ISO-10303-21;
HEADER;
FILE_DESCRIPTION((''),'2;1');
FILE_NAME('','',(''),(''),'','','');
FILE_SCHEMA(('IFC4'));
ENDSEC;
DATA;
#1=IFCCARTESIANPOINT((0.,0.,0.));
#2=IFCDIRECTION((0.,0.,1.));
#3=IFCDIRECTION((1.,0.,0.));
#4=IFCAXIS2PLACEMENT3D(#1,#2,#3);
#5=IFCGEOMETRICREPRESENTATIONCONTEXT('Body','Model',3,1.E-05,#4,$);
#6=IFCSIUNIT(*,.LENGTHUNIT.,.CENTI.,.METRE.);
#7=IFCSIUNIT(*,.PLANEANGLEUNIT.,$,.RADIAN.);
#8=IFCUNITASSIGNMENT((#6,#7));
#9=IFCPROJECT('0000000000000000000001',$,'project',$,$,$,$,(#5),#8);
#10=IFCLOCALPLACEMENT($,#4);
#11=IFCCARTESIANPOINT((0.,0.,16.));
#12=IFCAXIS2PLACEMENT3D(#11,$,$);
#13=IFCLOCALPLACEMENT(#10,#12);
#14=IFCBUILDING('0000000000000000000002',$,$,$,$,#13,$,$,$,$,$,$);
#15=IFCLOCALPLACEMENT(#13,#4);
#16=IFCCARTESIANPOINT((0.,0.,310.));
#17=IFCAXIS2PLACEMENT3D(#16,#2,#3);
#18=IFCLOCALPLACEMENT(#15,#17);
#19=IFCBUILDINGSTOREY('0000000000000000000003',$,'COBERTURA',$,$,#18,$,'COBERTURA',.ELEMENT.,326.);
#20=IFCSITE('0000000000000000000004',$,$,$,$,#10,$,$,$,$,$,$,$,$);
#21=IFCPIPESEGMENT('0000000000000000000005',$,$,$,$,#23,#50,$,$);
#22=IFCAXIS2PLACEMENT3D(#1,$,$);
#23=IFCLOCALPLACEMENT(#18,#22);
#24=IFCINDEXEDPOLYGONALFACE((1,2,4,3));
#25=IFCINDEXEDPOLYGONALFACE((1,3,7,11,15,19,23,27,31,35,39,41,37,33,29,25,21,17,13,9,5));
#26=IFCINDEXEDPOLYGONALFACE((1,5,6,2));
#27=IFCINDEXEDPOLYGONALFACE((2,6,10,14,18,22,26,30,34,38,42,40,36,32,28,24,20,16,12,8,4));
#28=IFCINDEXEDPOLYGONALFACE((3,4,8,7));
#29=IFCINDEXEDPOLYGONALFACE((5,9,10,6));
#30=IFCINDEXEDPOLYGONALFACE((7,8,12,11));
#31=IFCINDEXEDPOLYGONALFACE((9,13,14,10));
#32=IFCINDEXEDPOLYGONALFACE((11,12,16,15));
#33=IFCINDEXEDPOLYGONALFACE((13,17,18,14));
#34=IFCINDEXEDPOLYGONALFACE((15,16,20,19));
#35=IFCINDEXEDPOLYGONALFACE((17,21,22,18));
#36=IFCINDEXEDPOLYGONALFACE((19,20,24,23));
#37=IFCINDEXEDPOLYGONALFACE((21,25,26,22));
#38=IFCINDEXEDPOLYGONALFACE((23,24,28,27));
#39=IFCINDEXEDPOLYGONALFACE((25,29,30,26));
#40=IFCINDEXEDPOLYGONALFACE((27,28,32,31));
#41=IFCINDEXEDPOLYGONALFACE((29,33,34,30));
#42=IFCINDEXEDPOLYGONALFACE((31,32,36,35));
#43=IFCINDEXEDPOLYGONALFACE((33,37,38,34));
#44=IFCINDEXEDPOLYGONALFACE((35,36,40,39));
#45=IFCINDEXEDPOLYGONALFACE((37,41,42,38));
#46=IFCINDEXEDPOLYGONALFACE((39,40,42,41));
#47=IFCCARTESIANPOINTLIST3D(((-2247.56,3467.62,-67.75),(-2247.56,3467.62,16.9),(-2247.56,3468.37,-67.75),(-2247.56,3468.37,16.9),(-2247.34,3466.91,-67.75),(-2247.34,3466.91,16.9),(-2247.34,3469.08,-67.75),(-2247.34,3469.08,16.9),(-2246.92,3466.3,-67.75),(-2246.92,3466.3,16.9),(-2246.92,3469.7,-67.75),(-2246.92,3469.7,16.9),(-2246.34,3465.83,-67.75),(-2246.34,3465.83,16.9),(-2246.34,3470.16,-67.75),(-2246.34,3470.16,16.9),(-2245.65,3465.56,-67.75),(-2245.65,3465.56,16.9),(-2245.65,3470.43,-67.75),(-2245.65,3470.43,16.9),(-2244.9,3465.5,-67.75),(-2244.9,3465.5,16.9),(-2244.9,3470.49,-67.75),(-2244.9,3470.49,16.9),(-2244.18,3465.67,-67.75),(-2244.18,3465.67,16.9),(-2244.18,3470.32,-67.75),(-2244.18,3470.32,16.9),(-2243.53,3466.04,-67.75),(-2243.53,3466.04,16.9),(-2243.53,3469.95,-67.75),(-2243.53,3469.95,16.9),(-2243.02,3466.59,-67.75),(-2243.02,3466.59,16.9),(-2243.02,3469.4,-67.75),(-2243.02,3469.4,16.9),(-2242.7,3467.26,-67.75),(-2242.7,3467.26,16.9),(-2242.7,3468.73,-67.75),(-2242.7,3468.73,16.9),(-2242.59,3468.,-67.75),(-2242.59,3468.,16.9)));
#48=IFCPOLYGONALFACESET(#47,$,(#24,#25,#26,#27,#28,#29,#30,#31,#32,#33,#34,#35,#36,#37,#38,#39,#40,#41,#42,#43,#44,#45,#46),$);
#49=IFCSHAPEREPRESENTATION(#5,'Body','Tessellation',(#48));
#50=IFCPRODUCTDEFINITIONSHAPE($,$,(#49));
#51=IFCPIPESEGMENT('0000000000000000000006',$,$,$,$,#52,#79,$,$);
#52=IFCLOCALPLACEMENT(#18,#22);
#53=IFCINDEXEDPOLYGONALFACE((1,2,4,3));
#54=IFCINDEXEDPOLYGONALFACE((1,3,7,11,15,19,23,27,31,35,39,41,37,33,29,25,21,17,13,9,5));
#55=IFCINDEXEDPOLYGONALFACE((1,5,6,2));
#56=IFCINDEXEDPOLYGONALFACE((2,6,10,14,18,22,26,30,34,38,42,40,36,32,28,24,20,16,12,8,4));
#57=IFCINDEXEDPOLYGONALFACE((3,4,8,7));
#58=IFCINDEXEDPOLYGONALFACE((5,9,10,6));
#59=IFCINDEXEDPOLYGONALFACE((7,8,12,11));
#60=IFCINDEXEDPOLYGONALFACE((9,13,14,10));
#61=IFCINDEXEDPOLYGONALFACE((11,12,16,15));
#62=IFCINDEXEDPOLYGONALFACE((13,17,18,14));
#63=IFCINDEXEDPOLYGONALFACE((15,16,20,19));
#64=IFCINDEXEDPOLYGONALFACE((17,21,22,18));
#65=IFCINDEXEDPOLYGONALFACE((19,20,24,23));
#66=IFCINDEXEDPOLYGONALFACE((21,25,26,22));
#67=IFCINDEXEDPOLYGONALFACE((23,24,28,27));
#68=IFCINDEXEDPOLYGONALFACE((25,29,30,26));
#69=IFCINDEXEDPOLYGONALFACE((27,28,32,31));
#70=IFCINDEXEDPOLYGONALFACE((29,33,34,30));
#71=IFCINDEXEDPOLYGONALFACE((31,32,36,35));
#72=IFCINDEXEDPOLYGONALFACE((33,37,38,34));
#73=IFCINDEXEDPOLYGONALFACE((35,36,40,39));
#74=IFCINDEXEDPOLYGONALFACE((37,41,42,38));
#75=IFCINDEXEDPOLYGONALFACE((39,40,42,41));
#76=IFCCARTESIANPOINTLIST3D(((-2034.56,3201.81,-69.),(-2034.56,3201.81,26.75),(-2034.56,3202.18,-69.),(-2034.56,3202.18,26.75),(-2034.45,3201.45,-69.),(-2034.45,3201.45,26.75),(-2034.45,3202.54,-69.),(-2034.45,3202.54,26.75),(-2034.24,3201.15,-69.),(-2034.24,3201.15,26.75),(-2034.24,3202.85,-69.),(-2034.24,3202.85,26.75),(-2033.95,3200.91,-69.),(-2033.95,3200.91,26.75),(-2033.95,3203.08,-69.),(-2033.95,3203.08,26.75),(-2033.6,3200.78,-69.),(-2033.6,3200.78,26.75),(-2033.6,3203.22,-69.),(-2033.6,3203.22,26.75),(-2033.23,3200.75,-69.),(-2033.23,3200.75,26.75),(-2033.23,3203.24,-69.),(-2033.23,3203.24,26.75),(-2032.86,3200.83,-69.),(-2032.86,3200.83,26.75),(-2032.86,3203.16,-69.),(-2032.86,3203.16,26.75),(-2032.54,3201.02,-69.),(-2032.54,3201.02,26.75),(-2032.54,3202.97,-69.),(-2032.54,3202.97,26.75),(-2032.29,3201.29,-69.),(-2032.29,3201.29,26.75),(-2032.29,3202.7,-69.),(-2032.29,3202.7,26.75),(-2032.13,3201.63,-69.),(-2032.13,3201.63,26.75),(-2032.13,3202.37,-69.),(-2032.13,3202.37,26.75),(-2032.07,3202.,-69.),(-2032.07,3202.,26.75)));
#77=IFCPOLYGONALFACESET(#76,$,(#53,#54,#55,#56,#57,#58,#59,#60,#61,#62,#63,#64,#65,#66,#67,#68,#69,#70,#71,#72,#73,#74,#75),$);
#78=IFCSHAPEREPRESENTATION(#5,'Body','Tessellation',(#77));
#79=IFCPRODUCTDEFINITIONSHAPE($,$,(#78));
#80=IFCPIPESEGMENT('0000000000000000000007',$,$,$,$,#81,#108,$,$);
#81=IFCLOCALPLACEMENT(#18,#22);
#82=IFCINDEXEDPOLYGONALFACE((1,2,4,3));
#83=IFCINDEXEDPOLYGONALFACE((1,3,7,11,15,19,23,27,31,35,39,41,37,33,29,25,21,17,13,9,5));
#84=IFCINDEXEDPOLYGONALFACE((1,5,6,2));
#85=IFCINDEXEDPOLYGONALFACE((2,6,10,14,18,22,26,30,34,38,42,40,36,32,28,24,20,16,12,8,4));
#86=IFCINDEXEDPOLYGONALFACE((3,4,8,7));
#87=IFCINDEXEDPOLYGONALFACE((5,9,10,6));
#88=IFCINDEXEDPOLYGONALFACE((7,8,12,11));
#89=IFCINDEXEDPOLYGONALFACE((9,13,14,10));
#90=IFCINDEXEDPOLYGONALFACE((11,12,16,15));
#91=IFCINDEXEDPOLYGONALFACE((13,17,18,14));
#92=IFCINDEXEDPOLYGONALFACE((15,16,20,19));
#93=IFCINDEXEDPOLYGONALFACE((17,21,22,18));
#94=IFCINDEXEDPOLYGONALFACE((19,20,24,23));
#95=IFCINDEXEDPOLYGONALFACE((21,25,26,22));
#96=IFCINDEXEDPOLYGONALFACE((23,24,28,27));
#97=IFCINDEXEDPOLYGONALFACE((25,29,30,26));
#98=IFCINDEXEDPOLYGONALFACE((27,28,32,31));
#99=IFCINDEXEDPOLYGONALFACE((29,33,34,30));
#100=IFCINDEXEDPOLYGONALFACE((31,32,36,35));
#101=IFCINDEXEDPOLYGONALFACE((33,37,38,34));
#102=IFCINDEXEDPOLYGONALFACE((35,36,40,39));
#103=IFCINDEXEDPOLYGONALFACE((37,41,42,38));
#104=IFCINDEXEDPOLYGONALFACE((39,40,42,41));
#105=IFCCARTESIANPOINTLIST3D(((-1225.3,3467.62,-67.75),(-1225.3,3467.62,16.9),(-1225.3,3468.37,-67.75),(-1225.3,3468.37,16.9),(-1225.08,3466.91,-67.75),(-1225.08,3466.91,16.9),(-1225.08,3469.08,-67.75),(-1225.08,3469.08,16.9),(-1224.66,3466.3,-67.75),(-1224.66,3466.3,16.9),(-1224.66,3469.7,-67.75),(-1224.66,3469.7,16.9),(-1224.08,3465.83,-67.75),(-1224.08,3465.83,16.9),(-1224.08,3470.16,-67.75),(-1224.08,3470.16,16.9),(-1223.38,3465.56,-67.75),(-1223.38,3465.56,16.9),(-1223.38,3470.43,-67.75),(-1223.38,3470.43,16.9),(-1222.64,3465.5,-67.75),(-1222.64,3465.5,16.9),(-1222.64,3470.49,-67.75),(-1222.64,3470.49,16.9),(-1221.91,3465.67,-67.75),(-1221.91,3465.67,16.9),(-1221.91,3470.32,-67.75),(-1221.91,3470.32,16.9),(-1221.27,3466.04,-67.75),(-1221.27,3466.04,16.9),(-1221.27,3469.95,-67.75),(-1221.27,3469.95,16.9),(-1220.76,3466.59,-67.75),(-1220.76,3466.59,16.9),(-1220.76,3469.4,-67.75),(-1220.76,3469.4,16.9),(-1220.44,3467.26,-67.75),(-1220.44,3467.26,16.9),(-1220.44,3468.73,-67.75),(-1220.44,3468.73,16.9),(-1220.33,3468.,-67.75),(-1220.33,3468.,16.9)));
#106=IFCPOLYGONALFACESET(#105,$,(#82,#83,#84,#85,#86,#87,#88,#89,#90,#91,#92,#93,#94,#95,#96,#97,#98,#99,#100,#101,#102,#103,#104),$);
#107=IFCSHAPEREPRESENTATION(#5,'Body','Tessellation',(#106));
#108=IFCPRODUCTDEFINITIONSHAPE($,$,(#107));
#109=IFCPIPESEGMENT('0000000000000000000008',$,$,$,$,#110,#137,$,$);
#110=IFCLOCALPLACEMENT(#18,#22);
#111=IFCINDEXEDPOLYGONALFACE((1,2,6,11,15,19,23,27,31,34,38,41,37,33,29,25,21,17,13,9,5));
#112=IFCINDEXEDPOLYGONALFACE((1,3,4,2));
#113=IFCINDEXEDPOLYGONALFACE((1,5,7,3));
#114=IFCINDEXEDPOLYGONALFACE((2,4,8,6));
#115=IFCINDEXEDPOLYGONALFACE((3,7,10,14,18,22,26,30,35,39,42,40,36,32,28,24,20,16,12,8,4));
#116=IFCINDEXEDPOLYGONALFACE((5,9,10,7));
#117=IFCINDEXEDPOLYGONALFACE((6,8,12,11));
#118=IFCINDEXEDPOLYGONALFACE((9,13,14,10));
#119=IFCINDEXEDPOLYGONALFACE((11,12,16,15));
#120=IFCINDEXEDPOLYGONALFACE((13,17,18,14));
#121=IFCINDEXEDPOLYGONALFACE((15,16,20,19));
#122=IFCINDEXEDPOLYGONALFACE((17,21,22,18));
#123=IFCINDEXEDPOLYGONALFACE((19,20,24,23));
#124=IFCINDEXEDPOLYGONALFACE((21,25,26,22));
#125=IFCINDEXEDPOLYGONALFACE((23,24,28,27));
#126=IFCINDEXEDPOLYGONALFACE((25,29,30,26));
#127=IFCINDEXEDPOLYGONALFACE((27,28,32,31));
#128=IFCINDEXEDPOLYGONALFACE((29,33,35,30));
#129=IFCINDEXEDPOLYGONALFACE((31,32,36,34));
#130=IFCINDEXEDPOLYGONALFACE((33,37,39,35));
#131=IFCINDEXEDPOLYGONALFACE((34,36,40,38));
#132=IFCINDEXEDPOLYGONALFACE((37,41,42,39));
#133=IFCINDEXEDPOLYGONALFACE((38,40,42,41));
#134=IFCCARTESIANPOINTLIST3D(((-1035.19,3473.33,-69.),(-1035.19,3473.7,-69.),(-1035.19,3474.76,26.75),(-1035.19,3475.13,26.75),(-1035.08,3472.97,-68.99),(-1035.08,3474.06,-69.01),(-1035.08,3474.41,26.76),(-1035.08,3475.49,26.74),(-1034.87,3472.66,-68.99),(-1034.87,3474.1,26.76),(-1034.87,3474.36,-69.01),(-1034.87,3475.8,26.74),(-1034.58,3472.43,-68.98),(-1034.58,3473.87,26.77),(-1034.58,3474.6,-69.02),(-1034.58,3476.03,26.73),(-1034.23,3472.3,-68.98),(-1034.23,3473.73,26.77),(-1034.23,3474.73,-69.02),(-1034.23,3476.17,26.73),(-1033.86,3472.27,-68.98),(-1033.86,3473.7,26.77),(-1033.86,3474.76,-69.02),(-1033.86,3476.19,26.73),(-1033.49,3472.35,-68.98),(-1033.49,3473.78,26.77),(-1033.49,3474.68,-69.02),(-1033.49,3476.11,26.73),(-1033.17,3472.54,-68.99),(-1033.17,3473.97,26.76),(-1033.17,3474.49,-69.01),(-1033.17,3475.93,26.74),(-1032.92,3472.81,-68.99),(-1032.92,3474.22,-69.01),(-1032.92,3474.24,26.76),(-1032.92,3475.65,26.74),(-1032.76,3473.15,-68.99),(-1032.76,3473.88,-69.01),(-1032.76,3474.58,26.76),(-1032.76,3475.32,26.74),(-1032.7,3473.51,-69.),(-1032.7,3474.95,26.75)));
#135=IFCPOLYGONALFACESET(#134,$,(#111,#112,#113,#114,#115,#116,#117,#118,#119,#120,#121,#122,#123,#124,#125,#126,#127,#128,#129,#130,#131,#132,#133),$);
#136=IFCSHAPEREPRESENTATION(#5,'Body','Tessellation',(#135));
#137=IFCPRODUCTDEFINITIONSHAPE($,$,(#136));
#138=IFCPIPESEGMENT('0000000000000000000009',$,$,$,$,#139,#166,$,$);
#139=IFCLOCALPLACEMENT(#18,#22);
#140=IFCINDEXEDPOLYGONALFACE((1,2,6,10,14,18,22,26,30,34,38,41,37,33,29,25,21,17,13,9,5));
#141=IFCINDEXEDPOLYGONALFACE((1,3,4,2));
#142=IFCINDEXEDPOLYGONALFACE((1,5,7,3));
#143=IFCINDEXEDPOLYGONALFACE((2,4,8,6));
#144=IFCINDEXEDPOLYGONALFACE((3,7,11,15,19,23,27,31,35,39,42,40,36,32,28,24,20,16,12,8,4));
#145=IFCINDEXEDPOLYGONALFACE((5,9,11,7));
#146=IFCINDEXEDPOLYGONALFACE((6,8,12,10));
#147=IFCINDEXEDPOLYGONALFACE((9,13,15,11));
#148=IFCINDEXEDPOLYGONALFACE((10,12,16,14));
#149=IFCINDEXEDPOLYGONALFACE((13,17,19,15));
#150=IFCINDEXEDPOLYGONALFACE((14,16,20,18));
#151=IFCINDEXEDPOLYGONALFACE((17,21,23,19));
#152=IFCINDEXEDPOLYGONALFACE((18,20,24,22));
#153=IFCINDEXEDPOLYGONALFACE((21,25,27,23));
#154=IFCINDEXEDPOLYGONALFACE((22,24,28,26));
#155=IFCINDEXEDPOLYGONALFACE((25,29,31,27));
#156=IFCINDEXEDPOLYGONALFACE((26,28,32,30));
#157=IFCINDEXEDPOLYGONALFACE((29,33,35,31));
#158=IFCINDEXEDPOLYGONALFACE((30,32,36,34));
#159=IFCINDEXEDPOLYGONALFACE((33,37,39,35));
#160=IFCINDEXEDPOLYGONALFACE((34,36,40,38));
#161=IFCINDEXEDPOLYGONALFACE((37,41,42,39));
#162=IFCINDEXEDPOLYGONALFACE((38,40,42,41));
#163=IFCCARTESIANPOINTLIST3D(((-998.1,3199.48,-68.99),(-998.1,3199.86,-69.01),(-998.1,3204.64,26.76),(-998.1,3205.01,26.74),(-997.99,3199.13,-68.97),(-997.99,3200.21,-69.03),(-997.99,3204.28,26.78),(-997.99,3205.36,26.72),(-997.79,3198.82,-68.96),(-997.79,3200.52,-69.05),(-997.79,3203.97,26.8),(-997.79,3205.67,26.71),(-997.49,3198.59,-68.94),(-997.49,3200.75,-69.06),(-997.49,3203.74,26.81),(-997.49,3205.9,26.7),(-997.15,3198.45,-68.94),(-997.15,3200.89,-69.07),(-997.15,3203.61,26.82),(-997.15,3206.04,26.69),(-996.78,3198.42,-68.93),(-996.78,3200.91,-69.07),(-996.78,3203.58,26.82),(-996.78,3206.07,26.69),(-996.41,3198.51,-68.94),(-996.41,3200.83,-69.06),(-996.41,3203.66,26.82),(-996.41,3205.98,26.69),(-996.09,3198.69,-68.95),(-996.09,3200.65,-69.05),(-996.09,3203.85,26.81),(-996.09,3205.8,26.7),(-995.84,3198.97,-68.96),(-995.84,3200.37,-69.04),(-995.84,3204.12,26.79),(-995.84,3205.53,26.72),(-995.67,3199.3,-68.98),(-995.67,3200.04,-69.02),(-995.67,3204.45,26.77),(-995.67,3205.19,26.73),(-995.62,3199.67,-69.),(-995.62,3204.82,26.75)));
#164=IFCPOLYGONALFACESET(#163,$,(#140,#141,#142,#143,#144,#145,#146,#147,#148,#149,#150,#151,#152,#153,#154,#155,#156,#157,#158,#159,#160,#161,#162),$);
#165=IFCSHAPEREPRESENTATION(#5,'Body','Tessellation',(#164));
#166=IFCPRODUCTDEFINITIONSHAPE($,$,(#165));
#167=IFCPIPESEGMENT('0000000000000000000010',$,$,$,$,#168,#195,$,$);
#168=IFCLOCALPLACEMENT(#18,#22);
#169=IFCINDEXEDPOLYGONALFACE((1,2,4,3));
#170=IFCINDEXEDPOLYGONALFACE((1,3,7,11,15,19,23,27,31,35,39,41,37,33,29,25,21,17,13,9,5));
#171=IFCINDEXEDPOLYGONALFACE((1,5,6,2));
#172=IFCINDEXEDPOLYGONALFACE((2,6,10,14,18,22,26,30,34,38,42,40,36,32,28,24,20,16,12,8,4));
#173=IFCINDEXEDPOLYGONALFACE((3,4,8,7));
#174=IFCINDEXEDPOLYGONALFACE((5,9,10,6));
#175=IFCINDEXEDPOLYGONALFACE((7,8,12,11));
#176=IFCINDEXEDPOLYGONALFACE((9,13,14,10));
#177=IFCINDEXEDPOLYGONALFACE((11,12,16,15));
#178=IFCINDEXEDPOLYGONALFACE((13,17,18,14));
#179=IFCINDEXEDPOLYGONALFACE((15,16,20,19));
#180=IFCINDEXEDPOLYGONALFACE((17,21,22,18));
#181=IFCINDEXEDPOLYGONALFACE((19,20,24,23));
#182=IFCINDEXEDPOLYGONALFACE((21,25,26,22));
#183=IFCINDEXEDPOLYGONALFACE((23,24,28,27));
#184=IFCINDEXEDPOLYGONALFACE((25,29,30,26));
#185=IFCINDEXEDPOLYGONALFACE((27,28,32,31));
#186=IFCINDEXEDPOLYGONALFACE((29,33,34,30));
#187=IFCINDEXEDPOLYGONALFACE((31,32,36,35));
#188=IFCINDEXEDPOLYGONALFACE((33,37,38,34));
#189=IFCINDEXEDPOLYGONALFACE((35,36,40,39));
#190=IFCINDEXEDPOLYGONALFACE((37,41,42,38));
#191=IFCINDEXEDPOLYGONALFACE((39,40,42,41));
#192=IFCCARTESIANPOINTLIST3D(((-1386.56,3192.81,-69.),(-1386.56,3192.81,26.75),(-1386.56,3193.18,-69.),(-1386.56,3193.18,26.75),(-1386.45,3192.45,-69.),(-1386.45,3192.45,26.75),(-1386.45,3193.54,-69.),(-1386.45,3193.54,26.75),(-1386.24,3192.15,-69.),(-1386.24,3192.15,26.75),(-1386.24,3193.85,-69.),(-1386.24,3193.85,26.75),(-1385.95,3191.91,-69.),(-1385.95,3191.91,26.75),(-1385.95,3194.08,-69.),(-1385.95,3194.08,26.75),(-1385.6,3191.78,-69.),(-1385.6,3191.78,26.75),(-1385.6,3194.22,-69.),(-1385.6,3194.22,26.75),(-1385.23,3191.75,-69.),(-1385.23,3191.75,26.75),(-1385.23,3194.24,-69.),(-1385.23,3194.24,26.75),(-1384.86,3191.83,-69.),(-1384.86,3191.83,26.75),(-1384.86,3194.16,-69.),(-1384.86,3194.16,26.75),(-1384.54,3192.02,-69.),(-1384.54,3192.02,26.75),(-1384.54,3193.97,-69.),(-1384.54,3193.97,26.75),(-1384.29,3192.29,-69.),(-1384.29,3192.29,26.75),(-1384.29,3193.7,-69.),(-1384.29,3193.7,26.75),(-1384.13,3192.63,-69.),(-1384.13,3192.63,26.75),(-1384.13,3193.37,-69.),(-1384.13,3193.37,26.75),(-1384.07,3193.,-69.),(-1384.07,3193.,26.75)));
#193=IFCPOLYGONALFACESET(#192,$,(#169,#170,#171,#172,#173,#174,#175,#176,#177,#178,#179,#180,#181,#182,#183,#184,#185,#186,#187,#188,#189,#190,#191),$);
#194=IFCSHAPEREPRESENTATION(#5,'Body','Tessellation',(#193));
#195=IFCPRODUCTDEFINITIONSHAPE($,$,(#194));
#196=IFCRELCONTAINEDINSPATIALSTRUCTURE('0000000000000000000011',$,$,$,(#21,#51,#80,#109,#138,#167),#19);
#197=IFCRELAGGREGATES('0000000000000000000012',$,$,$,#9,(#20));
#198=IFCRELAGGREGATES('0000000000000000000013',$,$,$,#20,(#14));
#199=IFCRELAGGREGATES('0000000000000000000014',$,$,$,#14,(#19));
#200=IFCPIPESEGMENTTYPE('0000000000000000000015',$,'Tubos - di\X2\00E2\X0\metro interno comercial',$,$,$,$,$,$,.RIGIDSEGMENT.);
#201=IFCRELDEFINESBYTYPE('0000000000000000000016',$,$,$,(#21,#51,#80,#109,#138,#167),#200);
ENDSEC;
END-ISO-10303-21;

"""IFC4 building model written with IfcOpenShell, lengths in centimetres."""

from ifc_helpers import new_model, si_unit, frame, origin_with_axes, origin_2d_with_axis, place, context, project, spatial, circle, extrude, type_object, element, save


model = new_model("IFC4")

# Units and contexts
model_context = context("Model", 3, precision=1e-05, world=origin_with_axes(), identifier="Body")
ifc_project = project(units=[si_unit("LENGTHUNIT", "METRE", prefix="CENTI"), si_unit("PLANEANGLEUNIT", "RADIAN")], contexts=[model_context])

# Site, building, storey
site_placement = place(None, origin_with_axes())
site = spatial("IfcSite", under=ifc_project, at=site_placement)
building_placement = place(site_placement, frame((0.0, 0.0, 16.0)))
building = spatial("IfcBuilding", under=site, at=building_placement)
placement = place(building_placement, origin_with_axes())
storey_placement = place(placement, frame((0.0, 0.0, 310.0), z_axis=(0.0, 0.0, 1.0), x_axis=(1.0, 0.0, 0.0)))
storey = spatial("IfcBuildingStorey", under=building, at=storey_placement, Name="COBERTURA", LongName="COBERTURA", CompositionType="ELEMENT", Elevation=326.0)

# Pipe segments
pipe_segment_type = type_object("IfcPipeSegmentType", Name="Tubos - diâmetro interno comercial", PredefinedType="RIGIDSEGMENT")
pipe_segment_1_placement = place(storey_placement, frame((-2245.09, 3468.0, 16.9), z_axis=(0.0, 0.0, 1.0), x_axis=(1.0, 0.0, 0.0)))
element("IfcPipeSegment", 1, at=pipe_segment_1_placement, inside=storey, type_object=pipe_segment_type, context=model_context, shape_type="SolidModel", body=[
    extrude(circle(Radius=2.5, at=origin_2d_with_axis()), frame((0.0, 0.0, 0.0), z_axis=(0.0, 0.0, -1.0), x_axis=(1.0, 0.0, 0.0)), (0.0, 0.0, 1.0), 84.65),
])
pipe_segment_2_placement = place(storey_placement, frame((-2033.32, 3202.0, 26.75), z_axis=(0.0, 0.0, 1.0), x_axis=(1.0, 0.0, 0.0)))
element("IfcPipeSegment", 2, at=pipe_segment_2_placement, inside=storey, type_object=pipe_segment_type, context=model_context, shape_type="SolidModel", body=[
    extrude(circle(Radius=1.25, at=origin_2d_with_axis()), frame((0.0, 0.0, 0.0), z_axis=(0.0, 0.0, -1.0), x_axis=(1.0, 0.0, 0.0)), (0.0, 0.0, 1.0), 95.75),
])
pipe_segment_3_placement = place(storey_placement, frame((-1222.83, 3468.0, 16.9), z_axis=(0.0, 0.0, 1.0), x_axis=(1.0, 0.0, 0.0)))
element("IfcPipeSegment", 3, at=pipe_segment_3_placement, inside=storey, type_object=pipe_segment_type, context=model_context, shape_type="SolidModel", body=[
    extrude(circle(Radius=2.5, at=origin_2d_with_axis()), frame((0.0, 0.0, 0.0), z_axis=(0.0, 0.0, -1.0), x_axis=(1.0, 0.0, 0.0)), (0.0, 0.0, 1.0), 84.65),
])
pipe_segment_4_placement = place(storey_placement, frame((-1033.95, 3474.23, 26.77), z_axis=(0.0, 0.0, 1.0), x_axis=(1.0, 0.0, 0.0)))
element("IfcPipeSegment", 4, at=pipe_segment_4_placement, inside=storey, type_object=pipe_segment_type, context=model_context, shape_type="SolidModel", body=[
    extrude(circle(Radius=1.25, at=origin_2d_with_axis()), frame((0.0, 0.72, -0.02), z_axis=(0.0, -0.014972, -0.999888), x_axis=(1.0, 0.0, 0.0)), (0.0, 0.0, 1.0), 95.76),
])
pipe_segment_5_placement = place(storey_placement, frame((-996.87, 3202.25, 26.82), z_axis=(0.0, 0.0, 1.0), x_axis=(1.0, 0.0, 0.0)))
element("IfcPipeSegment", 5, at=pipe_segment_5_placement, inside=storey, type_object=pipe_segment_type, context=model_context, shape_type="SolidModel", body=[
    extrude(circle(Radius=1.25, at=origin_2d_with_axis()), frame((0.0, 2.58, -0.07), z_axis=(0.0, -0.053731, -0.998555), x_axis=(1.0, 0.0, 0.0)), (0.0, 0.0, 1.0), 95.89),
])
pipe_segment_6_placement = place(storey_placement, frame((-1385.32, 3193.0, 26.75), z_axis=(0.0, 0.0, 1.0), x_axis=(1.0, 0.0, 0.0)))
element("IfcPipeSegment", 6, at=pipe_segment_6_placement, inside=storey, type_object=pipe_segment_type, context=model_context, shape_type="SolidModel", body=[
    extrude(circle(Radius=1.25, at=origin_2d_with_axis()), frame((0.0, 0.0, 0.0), z_axis=(0.0, 0.0, -1.0), x_axis=(1.0, 0.0, 0.0)), (0.0, 0.0, 1.0), 95.75),
])

save(model, "model.ifc")
